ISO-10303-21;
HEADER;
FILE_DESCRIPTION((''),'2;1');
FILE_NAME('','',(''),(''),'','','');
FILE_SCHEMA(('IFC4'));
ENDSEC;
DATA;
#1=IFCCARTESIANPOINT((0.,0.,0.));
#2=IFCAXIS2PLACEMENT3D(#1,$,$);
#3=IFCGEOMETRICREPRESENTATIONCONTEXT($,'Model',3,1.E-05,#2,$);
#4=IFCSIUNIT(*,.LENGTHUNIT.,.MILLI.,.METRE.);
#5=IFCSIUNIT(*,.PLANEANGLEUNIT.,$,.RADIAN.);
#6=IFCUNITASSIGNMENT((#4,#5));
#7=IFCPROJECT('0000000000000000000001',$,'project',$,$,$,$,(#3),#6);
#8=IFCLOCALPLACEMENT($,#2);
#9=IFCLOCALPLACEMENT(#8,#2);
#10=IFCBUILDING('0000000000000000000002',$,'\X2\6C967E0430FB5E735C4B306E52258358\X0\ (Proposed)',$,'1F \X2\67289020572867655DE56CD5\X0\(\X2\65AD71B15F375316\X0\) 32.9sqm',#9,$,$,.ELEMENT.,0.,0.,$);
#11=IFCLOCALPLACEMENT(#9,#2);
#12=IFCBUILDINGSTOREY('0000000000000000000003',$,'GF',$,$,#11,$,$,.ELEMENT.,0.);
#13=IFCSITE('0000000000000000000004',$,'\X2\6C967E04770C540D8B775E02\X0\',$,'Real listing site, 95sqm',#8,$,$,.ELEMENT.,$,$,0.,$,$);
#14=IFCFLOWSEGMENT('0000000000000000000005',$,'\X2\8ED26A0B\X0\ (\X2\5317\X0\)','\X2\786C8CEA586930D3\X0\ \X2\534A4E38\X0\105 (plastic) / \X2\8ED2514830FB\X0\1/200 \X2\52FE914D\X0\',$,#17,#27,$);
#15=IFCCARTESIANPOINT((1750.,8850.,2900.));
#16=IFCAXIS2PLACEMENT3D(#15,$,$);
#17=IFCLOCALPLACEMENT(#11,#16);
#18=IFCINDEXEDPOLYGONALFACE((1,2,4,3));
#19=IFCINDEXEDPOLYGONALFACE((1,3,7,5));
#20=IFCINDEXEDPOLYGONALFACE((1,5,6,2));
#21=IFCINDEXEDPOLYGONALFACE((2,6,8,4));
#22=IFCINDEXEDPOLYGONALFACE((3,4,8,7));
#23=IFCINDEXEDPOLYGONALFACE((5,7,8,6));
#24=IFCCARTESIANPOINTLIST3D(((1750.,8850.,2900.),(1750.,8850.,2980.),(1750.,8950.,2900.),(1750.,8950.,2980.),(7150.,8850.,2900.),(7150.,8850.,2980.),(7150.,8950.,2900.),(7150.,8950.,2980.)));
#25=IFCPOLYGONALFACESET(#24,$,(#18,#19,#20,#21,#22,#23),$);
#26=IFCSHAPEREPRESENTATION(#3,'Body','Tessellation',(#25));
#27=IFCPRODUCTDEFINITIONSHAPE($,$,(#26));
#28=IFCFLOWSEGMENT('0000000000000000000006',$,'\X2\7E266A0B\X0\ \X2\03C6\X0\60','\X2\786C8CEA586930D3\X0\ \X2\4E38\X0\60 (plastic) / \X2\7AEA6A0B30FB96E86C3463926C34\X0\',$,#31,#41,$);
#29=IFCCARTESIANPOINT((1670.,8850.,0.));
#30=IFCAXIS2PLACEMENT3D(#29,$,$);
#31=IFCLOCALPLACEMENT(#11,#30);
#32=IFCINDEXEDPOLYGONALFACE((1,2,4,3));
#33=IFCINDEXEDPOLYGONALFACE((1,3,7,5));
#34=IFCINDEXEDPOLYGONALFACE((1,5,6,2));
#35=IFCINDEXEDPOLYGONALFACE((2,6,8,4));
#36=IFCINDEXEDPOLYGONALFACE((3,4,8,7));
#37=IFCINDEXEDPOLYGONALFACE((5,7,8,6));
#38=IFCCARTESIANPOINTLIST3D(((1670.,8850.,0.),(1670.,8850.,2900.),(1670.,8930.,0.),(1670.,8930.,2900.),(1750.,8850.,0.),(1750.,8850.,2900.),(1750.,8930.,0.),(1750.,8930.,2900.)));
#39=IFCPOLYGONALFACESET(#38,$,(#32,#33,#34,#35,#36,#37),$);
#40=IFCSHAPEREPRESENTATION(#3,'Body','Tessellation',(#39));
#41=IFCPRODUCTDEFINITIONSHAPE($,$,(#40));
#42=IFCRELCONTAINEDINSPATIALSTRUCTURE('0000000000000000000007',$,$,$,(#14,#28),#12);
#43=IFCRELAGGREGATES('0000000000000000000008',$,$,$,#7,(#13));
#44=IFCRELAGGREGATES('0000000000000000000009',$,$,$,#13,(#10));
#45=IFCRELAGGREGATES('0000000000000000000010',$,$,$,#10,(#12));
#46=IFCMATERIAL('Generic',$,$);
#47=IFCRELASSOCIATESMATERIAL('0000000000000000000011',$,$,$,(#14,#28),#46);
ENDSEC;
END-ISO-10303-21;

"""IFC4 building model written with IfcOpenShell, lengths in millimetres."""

from ifc_helpers import new_model, si_unit, frame, frame_2d, origin, place, context, project, spatial, rectangle, extrude, material, element, save


model = new_model("IFC4")

# Units and contexts
model_context = context("Model", 3, precision=1e-05, world=origin())
ifc_project = project(units=[si_unit("LENGTHUNIT", "METRE", prefix="MILLI"), si_unit("PLANEANGLEUNIT", "RADIAN")], contexts=[model_context])

# Site, building, storey
site_placement = place(None, origin())
site = spatial("IfcSite", under=ifc_project, at=site_placement, Name="沖縄県名護市", ObjectType="Real listing site, 95sqm", CompositionType="ELEMENT", RefElevation=0.0)
building_placement = place(site_placement, origin())
building = spatial("IfcBuilding", under=site, at=building_placement, Name="沖縄・平屋の別荘 (Proposed)", ObjectType="1F 木造在来工法(断熱強化) 32.9sqm", CompositionType="ELEMENT", ElevationOfRefHeight=0.0, ElevationOfTerrain=0.0)
storey_placement = place(building_placement, origin())
storey = spatial("IfcBuildingStorey", under=building, at=storey_placement, Name="GF", CompositionType="ELEMENT", Elevation=0.0)

# Shared definitions
ifc_material_1 = material(Name="Generic")

# Flow segments
flow_segment_1_placement = place(storey_placement, frame((1750.0, 8850.0, 2900.0)))
element("IfcFlowSegment", 1, at=flow_segment_1_placement, inside=storey, material=ifc_material_1, Name="軒樋 (北)", Description="硬質塩ビ 半丸105 (plastic) / 軒先・1/200 勾配", context=model_context, shape_type="SweptSolid", body=[
    extrude(rectangle(XDim=5400.0, YDim=100.0, at=frame_2d((2700.0, 50.0))), frame((1750.0, 8850.0, 2900.0)), (0.0, 0.0, 1.0), 80.0),
])
flow_segment_2_placement = place(storey_placement, frame((1670.0, 8850.0, 0.0)))
element("IfcFlowSegment", 2, at=flow_segment_2_placement, inside=storey, material=ifc_material_1, Name="縦樋 φ60", Description="硬質塩ビ 丸60 (plastic) / 竪樋・雨水排水", context=model_context, shape_type="SweptSolid", body=[
    extrude(rectangle(XDim=80.0, YDim=80.0, at=frame_2d((40.0, 40.0))), frame((1670.0, 8850.0, 0.0)), (0.0, 0.0, 1.0), 2900.0),
])

save(model, "model.ifc")
